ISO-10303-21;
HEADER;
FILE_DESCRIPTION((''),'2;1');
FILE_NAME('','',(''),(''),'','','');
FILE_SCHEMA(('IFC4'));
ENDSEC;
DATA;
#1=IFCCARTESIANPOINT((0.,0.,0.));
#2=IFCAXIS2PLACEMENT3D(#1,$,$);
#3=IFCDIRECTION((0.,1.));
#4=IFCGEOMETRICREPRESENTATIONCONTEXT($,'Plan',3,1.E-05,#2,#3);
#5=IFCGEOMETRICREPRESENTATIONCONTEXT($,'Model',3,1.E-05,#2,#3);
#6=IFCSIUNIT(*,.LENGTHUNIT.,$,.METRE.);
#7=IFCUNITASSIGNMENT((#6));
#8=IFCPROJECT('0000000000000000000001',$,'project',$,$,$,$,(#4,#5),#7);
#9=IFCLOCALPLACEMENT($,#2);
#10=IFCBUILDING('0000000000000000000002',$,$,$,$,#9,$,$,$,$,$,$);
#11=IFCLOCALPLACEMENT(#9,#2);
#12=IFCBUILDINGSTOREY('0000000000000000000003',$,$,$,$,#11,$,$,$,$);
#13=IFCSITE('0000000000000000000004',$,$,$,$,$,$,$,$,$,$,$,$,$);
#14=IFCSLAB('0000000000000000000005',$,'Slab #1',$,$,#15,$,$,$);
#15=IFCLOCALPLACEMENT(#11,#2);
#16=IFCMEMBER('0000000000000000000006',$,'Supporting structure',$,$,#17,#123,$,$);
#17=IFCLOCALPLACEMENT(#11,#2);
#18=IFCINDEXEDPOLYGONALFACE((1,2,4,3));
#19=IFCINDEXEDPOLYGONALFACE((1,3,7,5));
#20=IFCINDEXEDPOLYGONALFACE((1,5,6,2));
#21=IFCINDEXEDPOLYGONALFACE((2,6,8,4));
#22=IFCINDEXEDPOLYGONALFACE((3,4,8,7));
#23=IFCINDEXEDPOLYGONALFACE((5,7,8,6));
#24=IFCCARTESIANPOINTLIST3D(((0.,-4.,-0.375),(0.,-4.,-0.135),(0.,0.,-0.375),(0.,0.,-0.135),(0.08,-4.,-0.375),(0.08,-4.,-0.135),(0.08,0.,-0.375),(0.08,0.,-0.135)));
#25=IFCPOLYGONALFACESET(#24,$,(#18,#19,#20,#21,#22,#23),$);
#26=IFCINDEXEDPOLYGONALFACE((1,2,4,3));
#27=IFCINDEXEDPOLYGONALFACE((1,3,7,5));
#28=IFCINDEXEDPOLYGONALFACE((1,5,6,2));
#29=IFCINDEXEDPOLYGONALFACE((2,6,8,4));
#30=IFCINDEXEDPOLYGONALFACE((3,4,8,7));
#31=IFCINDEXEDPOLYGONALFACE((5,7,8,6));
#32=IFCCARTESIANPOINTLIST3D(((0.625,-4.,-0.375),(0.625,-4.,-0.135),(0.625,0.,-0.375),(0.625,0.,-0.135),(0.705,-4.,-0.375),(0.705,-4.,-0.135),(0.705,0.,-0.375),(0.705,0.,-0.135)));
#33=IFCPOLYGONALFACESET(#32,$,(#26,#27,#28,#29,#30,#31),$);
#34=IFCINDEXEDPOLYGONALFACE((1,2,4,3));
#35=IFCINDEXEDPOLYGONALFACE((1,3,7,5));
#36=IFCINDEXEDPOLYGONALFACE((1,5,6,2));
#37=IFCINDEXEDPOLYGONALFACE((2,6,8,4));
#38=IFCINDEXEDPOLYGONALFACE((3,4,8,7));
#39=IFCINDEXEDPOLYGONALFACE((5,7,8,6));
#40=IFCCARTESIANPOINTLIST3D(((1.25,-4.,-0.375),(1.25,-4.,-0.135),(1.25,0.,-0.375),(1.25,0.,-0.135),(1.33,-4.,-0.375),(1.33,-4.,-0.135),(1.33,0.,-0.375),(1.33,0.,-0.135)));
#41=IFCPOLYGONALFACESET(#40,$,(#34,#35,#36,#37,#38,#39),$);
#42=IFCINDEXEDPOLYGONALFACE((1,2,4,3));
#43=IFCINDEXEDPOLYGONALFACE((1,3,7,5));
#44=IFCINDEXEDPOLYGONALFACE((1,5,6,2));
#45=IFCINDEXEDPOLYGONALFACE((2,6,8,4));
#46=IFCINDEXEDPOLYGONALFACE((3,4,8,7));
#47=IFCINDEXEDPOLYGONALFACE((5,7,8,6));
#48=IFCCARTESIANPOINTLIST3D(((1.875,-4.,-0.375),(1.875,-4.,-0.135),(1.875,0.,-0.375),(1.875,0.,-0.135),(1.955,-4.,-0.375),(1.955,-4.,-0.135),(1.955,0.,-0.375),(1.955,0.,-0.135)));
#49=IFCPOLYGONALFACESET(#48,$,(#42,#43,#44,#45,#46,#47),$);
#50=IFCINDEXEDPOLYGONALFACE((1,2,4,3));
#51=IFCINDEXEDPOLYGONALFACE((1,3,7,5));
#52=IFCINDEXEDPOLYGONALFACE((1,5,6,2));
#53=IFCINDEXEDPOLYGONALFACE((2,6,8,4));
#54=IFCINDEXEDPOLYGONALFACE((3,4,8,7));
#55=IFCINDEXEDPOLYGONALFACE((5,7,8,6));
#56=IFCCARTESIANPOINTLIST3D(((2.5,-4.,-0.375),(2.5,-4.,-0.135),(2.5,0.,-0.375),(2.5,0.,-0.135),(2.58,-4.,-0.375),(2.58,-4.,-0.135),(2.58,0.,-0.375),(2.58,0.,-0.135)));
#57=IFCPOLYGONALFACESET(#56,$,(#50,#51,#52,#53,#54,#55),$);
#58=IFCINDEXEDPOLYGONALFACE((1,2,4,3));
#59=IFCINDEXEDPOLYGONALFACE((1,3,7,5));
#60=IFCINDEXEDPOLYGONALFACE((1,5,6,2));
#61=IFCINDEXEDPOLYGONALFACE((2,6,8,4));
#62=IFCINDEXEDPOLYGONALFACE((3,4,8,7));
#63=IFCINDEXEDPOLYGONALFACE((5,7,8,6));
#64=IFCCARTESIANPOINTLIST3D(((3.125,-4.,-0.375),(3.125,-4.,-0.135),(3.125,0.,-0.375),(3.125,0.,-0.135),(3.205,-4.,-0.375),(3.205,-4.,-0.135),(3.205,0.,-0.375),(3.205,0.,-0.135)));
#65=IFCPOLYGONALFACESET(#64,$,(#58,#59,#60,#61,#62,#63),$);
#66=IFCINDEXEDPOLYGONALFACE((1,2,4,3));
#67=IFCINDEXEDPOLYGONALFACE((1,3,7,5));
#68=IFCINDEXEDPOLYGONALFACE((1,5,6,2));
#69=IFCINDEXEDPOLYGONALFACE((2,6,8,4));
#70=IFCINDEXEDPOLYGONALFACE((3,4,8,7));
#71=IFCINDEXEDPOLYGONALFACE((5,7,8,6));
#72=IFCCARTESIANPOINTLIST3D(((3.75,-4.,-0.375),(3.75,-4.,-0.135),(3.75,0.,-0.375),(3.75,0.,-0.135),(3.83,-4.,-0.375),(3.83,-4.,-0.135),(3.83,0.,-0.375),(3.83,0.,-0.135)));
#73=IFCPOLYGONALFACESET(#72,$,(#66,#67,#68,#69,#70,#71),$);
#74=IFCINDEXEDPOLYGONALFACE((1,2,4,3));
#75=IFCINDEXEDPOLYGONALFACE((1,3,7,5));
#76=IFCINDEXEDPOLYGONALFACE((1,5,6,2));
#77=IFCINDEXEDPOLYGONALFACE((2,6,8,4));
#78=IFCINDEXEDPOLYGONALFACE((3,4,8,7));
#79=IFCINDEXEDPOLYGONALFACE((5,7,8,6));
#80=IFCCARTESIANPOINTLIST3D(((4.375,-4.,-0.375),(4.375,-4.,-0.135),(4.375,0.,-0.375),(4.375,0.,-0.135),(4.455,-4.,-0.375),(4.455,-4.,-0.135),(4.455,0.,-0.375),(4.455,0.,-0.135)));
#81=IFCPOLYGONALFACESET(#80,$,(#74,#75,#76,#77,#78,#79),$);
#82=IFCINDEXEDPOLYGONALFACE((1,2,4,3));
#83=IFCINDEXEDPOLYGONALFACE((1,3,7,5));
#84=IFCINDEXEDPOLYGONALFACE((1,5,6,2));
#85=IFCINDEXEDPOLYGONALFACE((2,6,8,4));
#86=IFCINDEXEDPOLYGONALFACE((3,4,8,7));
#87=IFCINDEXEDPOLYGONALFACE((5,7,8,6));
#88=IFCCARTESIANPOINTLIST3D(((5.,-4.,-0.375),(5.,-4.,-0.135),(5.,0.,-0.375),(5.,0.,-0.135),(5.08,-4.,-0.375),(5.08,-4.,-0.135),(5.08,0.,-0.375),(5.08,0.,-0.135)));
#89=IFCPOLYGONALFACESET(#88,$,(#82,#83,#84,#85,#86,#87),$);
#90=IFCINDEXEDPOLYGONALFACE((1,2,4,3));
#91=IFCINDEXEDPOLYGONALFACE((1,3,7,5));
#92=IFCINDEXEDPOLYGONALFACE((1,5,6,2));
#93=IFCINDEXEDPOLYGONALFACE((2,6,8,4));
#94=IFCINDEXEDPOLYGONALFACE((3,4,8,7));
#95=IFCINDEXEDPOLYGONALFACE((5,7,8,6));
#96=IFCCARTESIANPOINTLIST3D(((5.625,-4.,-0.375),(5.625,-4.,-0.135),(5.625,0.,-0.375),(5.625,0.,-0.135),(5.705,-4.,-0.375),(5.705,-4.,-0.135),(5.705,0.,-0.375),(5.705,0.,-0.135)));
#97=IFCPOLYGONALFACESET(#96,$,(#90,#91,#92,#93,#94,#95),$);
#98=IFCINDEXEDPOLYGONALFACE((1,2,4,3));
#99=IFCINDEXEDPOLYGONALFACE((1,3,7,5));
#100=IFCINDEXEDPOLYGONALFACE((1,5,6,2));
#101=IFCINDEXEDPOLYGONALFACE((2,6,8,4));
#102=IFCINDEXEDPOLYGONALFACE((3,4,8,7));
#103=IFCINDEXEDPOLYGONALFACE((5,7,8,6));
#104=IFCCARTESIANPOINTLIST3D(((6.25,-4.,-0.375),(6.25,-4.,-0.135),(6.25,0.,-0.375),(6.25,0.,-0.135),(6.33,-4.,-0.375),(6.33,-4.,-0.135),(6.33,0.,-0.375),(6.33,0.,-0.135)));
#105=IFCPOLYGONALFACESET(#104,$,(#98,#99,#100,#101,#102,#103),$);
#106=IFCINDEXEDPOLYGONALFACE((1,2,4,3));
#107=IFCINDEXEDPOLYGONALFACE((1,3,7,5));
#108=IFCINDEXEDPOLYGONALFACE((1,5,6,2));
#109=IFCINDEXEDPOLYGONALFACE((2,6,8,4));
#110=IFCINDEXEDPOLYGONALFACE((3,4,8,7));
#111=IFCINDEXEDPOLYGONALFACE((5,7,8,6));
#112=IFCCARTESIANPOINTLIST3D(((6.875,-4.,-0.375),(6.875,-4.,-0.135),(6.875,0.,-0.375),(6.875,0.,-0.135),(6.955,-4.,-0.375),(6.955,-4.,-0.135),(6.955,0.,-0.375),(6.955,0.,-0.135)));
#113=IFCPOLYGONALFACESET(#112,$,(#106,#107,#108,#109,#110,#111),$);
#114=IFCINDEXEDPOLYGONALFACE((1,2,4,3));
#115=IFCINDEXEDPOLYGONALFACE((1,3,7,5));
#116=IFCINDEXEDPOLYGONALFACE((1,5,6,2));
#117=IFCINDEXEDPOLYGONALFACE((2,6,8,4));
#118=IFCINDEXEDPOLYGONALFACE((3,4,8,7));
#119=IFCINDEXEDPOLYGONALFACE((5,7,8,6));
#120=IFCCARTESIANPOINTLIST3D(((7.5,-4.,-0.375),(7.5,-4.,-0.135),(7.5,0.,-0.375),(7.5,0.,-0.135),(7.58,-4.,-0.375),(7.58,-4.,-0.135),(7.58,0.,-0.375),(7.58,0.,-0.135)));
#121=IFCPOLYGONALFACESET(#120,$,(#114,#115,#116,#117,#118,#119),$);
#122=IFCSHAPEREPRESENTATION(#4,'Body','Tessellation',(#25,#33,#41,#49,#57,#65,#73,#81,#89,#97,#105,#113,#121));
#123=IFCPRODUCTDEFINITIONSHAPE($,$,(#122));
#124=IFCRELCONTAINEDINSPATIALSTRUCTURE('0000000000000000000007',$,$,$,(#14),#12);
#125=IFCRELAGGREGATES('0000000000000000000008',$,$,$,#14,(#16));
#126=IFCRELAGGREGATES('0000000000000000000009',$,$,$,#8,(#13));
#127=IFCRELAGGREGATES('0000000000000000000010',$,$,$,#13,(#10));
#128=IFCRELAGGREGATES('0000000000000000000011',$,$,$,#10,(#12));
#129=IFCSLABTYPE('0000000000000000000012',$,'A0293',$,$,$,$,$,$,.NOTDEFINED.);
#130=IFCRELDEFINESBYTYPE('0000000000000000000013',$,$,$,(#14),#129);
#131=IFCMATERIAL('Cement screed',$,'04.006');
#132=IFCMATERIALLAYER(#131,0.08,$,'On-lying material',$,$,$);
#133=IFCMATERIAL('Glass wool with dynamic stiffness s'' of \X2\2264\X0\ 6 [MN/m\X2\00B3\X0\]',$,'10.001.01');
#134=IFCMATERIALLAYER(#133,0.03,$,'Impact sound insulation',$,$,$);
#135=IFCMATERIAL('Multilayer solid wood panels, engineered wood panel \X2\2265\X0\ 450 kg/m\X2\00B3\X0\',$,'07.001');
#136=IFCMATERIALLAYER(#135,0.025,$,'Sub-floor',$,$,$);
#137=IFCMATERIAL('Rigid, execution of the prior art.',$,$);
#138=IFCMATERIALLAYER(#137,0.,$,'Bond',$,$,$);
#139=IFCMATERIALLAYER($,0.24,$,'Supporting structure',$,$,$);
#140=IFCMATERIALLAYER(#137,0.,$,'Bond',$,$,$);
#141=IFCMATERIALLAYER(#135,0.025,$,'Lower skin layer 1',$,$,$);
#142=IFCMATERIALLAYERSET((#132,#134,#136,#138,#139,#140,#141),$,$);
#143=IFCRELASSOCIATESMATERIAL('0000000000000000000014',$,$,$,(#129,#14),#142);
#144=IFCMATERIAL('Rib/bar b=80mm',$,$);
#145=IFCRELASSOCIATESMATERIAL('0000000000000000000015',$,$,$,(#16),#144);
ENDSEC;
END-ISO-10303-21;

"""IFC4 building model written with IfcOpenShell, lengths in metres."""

from ifc_helpers import new_model, si_unit, direction, frame, frame_2d, origin, place, context, project, spatial, rectangle, extrude, material, layer, layer_set, type_object, element, aggregate, save


model = new_model("IFC4")

# Units and contexts
plan_context = context("Plan", 3, precision=1e-05, world=origin(), true_north=direction((0.0, 1.0)))
model_context = context("Model", 3, precision=1e-05, world=origin(), true_north=direction((0.0, 1.0)))
ifc_project = project(units=[si_unit("LENGTHUNIT", "METRE")], contexts=[plan_context, model_context])

# Site, building, storey
site = spatial("IfcSite", under=ifc_project)
building_placement = place(None, origin())
building = spatial("IfcBuilding", under=site, at=building_placement)
storey_placement = place(building_placement, origin())
storey = spatial("IfcBuildingStorey", under=building, at=storey_placement)

# Slab, member
ifc_material_1 = material(Name="Cement screed", Category="04.006")
ifc_layer_1 = layer(ifc_material_1, 0.08, Name="On-lying material")
ifc_material_2 = material(Name="Glass wool with dynamic stiffness s' of ≤ 6 [MN/m³]", Category="10.001.01")
ifc_layer_2 = layer(ifc_material_2, 0.03, Name="Impact sound insulation")
ifc_material_3 = material(Name="Multilayer solid wood panels, engineered wood panel ≥ 450 kg/m³", Category="07.001")
ifc_layer_3 = layer(ifc_material_3, 0.025, Name="Sub-floor")
ifc_material_4 = material(Name="Rigid, execution of the prior art.")
ifc_layer_4 = layer(ifc_material_4, 0.0, Name="Bond")
ifc_layer_5 = layer(None, 0.24, Name="Supporting structure")
ifc_layer_6 = layer(ifc_material_4, 0.0, Name="Bond")
ifc_layer_7 = layer(ifc_material_3, 0.025, Name="Lower skin layer 1")
ifc_layer_set = layer_set([ifc_layer_1, ifc_layer_2, ifc_layer_3, ifc_layer_4, ifc_layer_5, ifc_layer_6, ifc_layer_7])
slab_type = type_object("IfcSlabType", Name="A0293", PredefinedType="NOTDEFINED", material=ifc_layer_set)
slab_placement = place(None, frame((0.0, 0.0, 0.0), z_axis=(0.0, 0.0, -1.0), x_axis=(1.0, 0.0, 0.0)))
slab = element("IfcSlab", 1, at=slab_placement, inside=storey, type_object=slab_type, material=ifc_layer_set, Name="Slab #1")
ifc_material_5 = material(Name="Rib/bar b=80mm")
member_1_placement = place(slab_placement, origin())
member_1 = element("IfcMember", 2, at=member_1_placement, material=ifc_material_5, Name="Supporting structure", context=plan_context, shape_type="SweptSolid", body=[
    extrude(rectangle(XDim=0.08, YDim=0.24, at=frame_2d((0.04, 0.12), x_axis=(1.0, 0.0))), frame((0.0, 4.0, 0.135), z_axis=(0.0, -1.0, 0.0), x_axis=(1.0, 0.0, 0.0)), (0.0, 0.0, 1.0), 4.0),
    extrude(rectangle(XDim=0.08, YDim=0.24, at=frame_2d((0.04, 0.12), x_axis=(1.0, 0.0))), frame((0.625, 4.0, 0.135), z_axis=(0.0, -1.0, 0.0), x_axis=(1.0, 0.0, 0.0)), (0.0, 0.0, 1.0), 4.0),
    extrude(rectangle(XDim=0.08, YDim=0.24, at=frame_2d((0.04, 0.12), x_axis=(1.0, 0.0))), frame((1.25, 4.0, 0.135), z_axis=(0.0, -1.0, 0.0), x_axis=(1.0, 0.0, 0.0)), (0.0, 0.0, 1.0), 4.0),
    extrude(rectangle(XDim=0.08, YDim=0.24, at=frame_2d((0.04, 0.12), x_axis=(1.0, 0.0))), frame((1.875, 4.0, 0.135), z_axis=(0.0, -1.0, 0.0), x_axis=(1.0, 0.0, 0.0)), (0.0, 0.0, 1.0), 4.0),
    extrude(rectangle(XDim=0.08, YDim=0.24, at=frame_2d((0.04, 0.12), x_axis=(1.0, 0.0))), frame((2.5, 4.0, 0.135), z_axis=(0.0, -1.0, 0.0), x_axis=(1.0, 0.0, 0.0)), (0.0, 0.0, 1.0), 4.0),
    extrude(rectangle(XDim=0.08, YDim=0.24, at=frame_2d((0.04, 0.12), x_axis=(1.0, 0.0))), frame((3.125, 4.0, 0.135), z_axis=(0.0, -1.0, 0.0), x_axis=(1.0, 0.0, 0.0)), (0.0, 0.0, 1.0), 4.0),
    extrude(rectangle(XDim=0.08, YDim=0.24, at=frame_2d((0.04, 0.12), x_axis=(1.0, 0.0))), frame((3.75, 4.0, 0.135), z_axis=(0.0, -1.0, 0.0), x_axis=(1.0, 0.0, 0.0)), (0.0, 0.0, 1.0), 4.0),
    extrude(rectangle(XDim=0.08, YDim=0.24, at=frame_2d((0.04, 0.12), x_axis=(1.0, 0.0))), frame((4.375, 4.0, 0.135), z_axis=(0.0, -1.0, 0.0), x_axis=(1.0, 0.0, 0.0)), (0.0, 0.0, 1.0), 4.0),
    extrude(rectangle(XDim=0.08, YDim=0.24, at=frame_2d((0.04, 0.12), x_axis=(1.0, 0.0))), frame((5.0, 4.0, 0.135), z_axis=(0.0, -1.0, 0.0), x_axis=(1.0, 0.0, 0.0)), (0.0, 0.0, 1.0), 4.0),
    extrude(rectangle(XDim=0.08, YDim=0.24, at=frame_2d((0.04, 0.12), x_axis=(1.0, 0.0))), frame((5.625, 4.0, 0.135), z_axis=(0.0, -1.0, 0.0), x_axis=(1.0, 0.0, 0.0)), (0.0, 0.0, 1.0), 4.0),
    extrude(rectangle(XDim=0.08, YDim=0.24, at=frame_2d((0.04, 0.12), x_axis=(1.0, 0.0))), frame((6.25, 4.0, 0.135), z_axis=(0.0, -1.0, 0.0), x_axis=(1.0, 0.0, 0.0)), (0.0, 0.0, 1.0), 4.0),
    extrude(rectangle(XDim=0.08, YDim=0.24, at=frame_2d((0.04, 0.12), x_axis=(1.0, 0.0))), frame((6.875, 4.0, 0.135), z_axis=(0.0, -1.0, 0.0), x_axis=(1.0, 0.0, 0.0)), (0.0, 0.0, 1.0), 4.0),
    extrude(rectangle(XDim=0.08, YDim=0.24, at=frame_2d((0.04, 0.12), x_axis=(1.0, 0.0))), frame((7.5, 4.0, 0.135), z_axis=(0.0, -1.0, 0.0), x_axis=(1.0, 0.0, 0.0)), (0.0, 0.0, 1.0), 4.0),
])
aggregate(slab, [member_1])

save(model, "model.ifc")
